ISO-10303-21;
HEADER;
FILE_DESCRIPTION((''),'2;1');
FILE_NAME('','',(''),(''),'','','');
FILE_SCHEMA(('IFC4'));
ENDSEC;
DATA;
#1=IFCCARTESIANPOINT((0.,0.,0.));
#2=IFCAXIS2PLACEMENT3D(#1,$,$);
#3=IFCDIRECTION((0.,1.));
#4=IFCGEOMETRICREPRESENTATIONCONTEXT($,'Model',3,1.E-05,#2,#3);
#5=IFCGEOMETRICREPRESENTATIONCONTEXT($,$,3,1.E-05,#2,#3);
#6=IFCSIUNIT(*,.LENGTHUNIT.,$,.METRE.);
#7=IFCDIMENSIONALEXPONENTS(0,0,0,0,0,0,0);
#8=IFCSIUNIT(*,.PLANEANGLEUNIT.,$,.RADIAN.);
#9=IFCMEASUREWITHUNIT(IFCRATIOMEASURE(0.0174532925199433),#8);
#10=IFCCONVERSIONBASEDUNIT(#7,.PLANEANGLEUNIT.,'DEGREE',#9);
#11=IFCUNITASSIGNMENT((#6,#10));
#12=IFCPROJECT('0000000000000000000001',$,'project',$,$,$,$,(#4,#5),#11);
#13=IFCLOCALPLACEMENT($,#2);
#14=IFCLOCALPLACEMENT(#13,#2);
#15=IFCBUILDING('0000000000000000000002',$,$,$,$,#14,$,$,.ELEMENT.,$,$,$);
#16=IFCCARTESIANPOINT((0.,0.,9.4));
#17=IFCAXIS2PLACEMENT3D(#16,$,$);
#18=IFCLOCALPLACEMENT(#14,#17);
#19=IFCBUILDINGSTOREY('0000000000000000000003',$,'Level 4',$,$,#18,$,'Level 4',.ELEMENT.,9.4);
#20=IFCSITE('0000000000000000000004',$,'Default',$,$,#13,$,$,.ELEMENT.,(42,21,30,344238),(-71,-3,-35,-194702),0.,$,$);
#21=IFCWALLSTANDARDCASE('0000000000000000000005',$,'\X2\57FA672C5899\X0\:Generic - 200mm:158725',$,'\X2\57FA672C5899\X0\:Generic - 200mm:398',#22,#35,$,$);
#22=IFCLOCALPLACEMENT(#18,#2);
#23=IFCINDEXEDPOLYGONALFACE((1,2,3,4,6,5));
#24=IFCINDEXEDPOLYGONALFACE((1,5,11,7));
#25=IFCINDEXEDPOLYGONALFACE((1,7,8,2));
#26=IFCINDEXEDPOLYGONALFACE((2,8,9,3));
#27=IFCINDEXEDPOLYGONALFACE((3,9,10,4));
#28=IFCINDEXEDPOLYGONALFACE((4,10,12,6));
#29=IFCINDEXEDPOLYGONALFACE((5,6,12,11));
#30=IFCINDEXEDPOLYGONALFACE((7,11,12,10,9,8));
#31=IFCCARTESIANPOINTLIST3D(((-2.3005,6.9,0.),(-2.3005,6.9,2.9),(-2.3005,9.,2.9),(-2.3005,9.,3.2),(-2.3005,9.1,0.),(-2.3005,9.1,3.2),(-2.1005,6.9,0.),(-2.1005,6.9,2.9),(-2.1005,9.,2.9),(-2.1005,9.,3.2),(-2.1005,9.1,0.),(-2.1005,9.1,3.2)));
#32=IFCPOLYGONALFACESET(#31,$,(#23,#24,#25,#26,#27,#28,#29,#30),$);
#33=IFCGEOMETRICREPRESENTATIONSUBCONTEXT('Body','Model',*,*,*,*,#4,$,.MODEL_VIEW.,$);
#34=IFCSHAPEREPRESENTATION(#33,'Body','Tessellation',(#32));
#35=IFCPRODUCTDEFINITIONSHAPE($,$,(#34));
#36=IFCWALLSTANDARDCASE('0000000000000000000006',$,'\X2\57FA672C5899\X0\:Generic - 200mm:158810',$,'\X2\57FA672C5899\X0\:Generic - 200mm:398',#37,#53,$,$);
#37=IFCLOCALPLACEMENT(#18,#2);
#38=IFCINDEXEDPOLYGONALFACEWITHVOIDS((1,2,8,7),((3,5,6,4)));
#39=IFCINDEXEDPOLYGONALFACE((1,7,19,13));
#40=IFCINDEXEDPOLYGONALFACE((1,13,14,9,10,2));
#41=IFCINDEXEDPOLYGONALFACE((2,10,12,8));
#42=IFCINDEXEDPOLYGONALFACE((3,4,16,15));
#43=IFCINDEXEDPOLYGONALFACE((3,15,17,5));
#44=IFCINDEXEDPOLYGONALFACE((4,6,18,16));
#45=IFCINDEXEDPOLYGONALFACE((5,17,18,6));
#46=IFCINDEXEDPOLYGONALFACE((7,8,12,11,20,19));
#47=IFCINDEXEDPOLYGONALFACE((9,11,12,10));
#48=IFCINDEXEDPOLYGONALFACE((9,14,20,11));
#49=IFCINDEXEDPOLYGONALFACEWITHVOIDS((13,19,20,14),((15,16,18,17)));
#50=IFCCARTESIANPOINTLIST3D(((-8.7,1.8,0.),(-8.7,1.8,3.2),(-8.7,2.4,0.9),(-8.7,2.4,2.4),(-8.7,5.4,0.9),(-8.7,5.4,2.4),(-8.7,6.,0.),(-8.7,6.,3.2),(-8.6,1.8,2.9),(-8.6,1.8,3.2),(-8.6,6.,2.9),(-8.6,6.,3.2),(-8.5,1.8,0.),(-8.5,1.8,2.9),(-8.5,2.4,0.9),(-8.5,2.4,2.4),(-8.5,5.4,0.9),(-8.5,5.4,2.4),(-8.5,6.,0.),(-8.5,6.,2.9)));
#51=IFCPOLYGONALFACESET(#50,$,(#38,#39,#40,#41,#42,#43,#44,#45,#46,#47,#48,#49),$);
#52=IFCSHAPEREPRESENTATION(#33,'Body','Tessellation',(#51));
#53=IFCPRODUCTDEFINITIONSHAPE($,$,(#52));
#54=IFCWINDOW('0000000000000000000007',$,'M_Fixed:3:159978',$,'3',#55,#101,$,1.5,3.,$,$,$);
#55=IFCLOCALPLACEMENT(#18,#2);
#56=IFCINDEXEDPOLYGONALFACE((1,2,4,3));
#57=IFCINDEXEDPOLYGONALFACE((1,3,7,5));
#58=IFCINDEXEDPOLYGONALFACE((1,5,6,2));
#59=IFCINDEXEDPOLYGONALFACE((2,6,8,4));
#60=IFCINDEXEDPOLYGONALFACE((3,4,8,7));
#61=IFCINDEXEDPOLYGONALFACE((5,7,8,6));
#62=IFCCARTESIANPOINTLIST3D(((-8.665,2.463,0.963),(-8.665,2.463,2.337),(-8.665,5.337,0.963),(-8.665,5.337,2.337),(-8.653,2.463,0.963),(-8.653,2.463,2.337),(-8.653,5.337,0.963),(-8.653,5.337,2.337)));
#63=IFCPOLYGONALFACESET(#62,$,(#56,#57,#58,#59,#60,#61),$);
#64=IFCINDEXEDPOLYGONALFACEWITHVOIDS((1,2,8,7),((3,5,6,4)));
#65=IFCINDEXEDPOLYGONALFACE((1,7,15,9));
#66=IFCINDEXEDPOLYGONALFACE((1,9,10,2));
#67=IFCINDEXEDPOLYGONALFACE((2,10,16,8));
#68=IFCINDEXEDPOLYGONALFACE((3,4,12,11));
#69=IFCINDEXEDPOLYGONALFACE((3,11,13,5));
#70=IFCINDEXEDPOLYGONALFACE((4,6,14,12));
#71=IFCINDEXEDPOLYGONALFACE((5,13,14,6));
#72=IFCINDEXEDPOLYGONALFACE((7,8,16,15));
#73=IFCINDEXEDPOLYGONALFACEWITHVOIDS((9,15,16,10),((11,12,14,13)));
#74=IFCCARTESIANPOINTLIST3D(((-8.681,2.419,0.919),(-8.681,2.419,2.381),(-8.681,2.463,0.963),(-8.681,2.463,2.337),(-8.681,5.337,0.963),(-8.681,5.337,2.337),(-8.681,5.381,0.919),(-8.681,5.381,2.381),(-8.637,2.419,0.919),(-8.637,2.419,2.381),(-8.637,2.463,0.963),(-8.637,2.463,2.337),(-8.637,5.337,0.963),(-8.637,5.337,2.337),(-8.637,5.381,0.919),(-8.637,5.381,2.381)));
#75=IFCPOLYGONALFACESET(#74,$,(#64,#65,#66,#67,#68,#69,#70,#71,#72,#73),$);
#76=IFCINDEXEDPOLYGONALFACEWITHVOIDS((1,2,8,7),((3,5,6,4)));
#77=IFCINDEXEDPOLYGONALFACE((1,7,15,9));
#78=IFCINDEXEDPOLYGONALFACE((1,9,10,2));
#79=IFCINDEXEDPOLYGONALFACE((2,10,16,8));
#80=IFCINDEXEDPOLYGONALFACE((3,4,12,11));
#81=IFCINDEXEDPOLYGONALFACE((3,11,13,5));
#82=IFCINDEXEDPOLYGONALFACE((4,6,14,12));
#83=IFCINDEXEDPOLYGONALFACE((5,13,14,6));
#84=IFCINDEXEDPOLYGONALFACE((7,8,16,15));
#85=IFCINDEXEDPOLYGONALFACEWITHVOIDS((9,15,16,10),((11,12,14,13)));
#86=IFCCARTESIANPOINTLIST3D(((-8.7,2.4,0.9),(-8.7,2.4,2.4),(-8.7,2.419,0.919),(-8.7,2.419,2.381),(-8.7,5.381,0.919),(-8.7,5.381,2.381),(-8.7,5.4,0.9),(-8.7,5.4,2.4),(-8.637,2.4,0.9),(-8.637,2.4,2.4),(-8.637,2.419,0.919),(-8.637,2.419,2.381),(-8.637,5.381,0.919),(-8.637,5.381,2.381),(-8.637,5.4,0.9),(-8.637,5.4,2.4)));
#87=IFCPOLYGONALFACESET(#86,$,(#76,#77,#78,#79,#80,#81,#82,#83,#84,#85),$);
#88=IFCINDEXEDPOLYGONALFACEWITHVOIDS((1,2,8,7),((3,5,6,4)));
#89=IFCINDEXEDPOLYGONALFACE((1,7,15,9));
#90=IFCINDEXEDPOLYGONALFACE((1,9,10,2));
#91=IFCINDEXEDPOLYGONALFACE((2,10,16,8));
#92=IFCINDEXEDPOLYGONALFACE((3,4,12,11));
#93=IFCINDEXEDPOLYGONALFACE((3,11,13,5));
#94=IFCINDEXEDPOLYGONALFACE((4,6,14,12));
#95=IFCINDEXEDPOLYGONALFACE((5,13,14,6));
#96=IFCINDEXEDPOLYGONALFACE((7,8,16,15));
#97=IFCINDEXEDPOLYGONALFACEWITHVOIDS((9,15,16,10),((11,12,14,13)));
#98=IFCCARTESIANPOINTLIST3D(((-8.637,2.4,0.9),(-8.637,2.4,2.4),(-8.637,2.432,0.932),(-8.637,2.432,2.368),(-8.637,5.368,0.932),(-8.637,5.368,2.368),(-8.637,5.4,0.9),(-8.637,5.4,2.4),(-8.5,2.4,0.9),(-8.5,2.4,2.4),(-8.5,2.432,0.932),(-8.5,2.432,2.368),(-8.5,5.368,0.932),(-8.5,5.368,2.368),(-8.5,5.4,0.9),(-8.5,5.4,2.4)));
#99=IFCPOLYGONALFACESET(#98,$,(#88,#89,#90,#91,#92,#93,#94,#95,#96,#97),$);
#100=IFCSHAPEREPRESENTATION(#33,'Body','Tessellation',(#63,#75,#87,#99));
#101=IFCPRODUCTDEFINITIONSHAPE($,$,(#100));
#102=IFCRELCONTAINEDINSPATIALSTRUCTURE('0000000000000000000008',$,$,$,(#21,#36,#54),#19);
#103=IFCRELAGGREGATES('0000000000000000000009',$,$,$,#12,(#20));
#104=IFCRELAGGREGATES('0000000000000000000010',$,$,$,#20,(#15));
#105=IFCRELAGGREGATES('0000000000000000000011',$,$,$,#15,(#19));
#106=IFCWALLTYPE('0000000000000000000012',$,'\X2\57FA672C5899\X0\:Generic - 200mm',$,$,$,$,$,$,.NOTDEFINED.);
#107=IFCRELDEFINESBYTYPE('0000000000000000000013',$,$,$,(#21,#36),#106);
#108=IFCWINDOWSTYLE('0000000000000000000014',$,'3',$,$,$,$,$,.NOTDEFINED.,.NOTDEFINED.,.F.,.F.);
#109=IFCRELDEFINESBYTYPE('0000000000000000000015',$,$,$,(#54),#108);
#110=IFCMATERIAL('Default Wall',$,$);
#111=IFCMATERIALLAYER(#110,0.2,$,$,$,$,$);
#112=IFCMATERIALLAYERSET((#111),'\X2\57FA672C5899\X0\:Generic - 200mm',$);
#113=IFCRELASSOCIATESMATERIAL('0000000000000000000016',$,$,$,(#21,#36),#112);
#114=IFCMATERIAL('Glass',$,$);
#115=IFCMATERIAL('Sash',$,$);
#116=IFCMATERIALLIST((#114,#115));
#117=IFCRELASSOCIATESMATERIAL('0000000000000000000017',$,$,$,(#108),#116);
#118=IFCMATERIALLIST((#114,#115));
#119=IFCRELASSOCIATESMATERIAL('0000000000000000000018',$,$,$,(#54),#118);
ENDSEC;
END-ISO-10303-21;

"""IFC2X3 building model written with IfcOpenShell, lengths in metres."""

from ifc_helpers import new_model, entity, si_unit, converted_unit, direction, frame, frame_2d, origin, place, context, subcontext, project, spatial, polyline, rectangle, outline, extrude, clip, bounded_halfspace, source, transform, mapped, material, material_list, layer, layer_set, layer_usage, type_object, type_shapes, element, fill, save


model = new_model("IFC2X3")

# Units and contexts
model_context = context("Model", 3, precision=1e-05, world=origin(), true_north=direction((0.0, 1.0)))
context_of_model = context(None, 3, precision=1e-05, world=origin(), true_north=direction((0.0, 1.0)))
body_context = subcontext(model_context, "Body", "Model", "MODEL_VIEW")
ifc_project = project(units=[si_unit("LENGTHUNIT", "METRE"), converted_unit("PLANEANGLEUNIT", "DEGREE", entity("IfcRatioMeasure", 0.0174532925199433), si_unit("PLANEANGLEUNIT", "RADIAN"), dimensions=[0, 0, 0, 0, 0, 0, 0])], contexts=[model_context, context_of_model])

# Site, building, storey
site_placement = place(None, origin())
site = spatial("IfcSite", under=ifc_project, at=site_placement, Name="Default", CompositionType="ELEMENT", RefLatitude=(42, 21, 30, 344238), RefLongitude=(-71, -3, -35, -194702), RefElevation=0.0)
building_placement = place(site_placement, origin())
building = spatial("IfcBuilding", under=site, at=building_placement, CompositionType="ELEMENT")
storey_placement = place(building_placement, frame((0.0, 0.0, 9.4)))
storey = spatial("IfcBuildingStorey", under=building, at=storey_placement, Name="Level 4", LongName="Level 4", CompositionType="ELEMENT", Elevation=9.4)

# Wall
ifc_material_1 = material(Name="Default Wall")
ifc_layer_1 = layer(ifc_material_1, 0.2)
ifc_layer_set_1 = layer_set([ifc_layer_1], Name="基本墙:Generic - 200mm")
ifc_layer_usage_1 = layer_usage(ifc_layer_set_1, "AXIS2", "NEGATIVE", 0.1)
wall_type_1 = type_object("IfcWallType", Name="基本墙:Generic - 200mm", PredefinedType="NOTDEFINED")
wall_1_placement = place(storey_placement, frame((-2.2005, 6.9, 0.0), z_axis=(0.0, 0.0, 1.0), x_axis=(0.0, 1.0, 0.0)))
element("IfcWallStandardCase", 1, at=wall_1_placement, inside=storey, type_object=wall_type_1, material=ifc_layer_usage_1, Name="基本墙:Generic - 200mm:158725", ObjectType="基本墙:Generic - 200mm:398", context=body_context, shape_type="Clipping", body=[
    clip(clip(extrude(rectangle(XDim=2.2, YDim=0.2, at=frame_2d((1.1, 0.0), x_axis=(-1.0, 0.0))), origin(), (0.0, 0.0, 1.0), 3.2), bounded_halfspace(frame((2.1, -0.1, 2.9), z_axis=(0.0, 0.0, -1.0), x_axis=(-1.0, 0.0, 0.0)), True, frame((2.1, -0.1, 2.9), z_axis=(0.0, 0.0, -1.0), x_axis=(-1.0, 0.0, 0.0)), polyline([(0.0, 0.0), (0.1, 0.0), (2.1, 0.0), (2.1, 0.1), (2.1, 0.2), (2.0, 0.2), (0.0, 0.2), (0.0, 0.0)]))), bounded_halfspace(frame((2.1, 0.1, 2.9), z_axis=(1.0, 0.0, 0.0), x_axis=(0.0, 0.0, 1.0)), True, frame((2.1, 0.1, 2.9), z_axis=(1.0, 0.0, 0.0), x_axis=(0.0, 0.0, 1.0)), polyline([(0.0, 0.0), (0.3, 0.0), (0.3, 0.2), (0.0, 0.2), (0.0, 0.0)]))),
])

# Wall, opening, window
ifc_layer_usage_2 = layer_usage(ifc_layer_set_1, "AXIS2", "NEGATIVE", 0.1)
wall_2_placement = place(storey_placement, frame((-8.6, 1.8, 0.0), z_axis=(0.0, 0.0, 1.0), x_axis=(0.0, 1.0, 0.0)))
wall_2 = element("IfcWallStandardCase", 2, at=wall_2_placement, inside=storey, type_object=wall_type_1, material=ifc_layer_usage_2, Name="基本墙:Generic - 200mm:158810", ObjectType="基本墙:Generic - 200mm:398", context=body_context, shape_type="Clipping", body=[
    clip(clip(extrude(rectangle(XDim=4.2, YDim=0.2, at=frame_2d((2.1, 0.0), x_axis=(-1.0, 0.0))), origin(), (0.0, 0.0, 1.0), 3.2), bounded_halfspace(frame((4.2, 0.0, 2.9), z_axis=(0.0, 0.0, -1.0), x_axis=(-1.0, 0.0, 0.0)), True, frame((4.2, 0.0, 2.9), z_axis=(0.0, 0.0, -1.0), x_axis=(-1.0, 0.0, 0.0)), polyline([(0.0, 0.0), (0.0, -0.1), (0.1, -0.1), (4.1, -0.1), (4.2, -0.1), (4.2, 0.0), (0.0, 0.0)]))), bounded_halfspace(frame((0.0, 0.0, 2.9), z_axis=(0.0, 1.0, 0.0), x_axis=(0.0, 0.0, 1.0)), True, frame((0.0, 0.0, 2.9), z_axis=(0.0, 1.0, 0.0), x_axis=(0.0, 0.0, 1.0)), polyline([(0.0, 0.0), (0.3, 0.0), (0.3, 4.2), (0.0, 4.2), (0.0, 0.0)]))),
])
opening_1_placement = place(wall_2_placement, frame((0.6, -0.1, 0.9)))
opening_1 = element("IfcOpeningElement", 3, at=opening_1_placement, cuts=wall_2, ObjectType="Opening", context=body_context, shape_type="SweptSolid", body=[
    extrude(rectangle(XDim=1.5, YDim=3.0, at=frame_2d((0.75, 1.5), x_axis=(1.0, 0.0))), frame((0.0, 0.0, 0.0), z_axis=(0.0, 1.0, 0.0), x_axis=(0.0, 0.0, 1.0)), (0.0, 0.0, 1.0), 0.2),
])
ifc_material_2 = material(Name="Glass")
ifc_material_3 = material(Name="Sash")
ifc_material_list_1 = material_list([ifc_material_2, ifc_material_3])
ifc_material_list_2 = material_list([ifc_material_2, ifc_material_3])
window_style_1 = type_object("IfcWindowStyle", Name="3", ConstructionType="NOTDEFINED", OperationType="NOTDEFINED", ParameterTakesPrecedence=False, Sizeable=False, material=ifc_material_list_2)
shared_shape_1 = source(origin(), body_context, "Body", "SweptSolid", [
    extrude(rectangle(XDim=0.012, YDim=2.874, at=frame_2d((0.0, 0.0), x_axis=(1.0, 0.0))), frame((1.5, 0.159, 0.063), z_axis=(0.0, 0.0, 1.0), x_axis=(0.0, -1.0, 0.0)), (0.0, 0.0, 1.0), 1.374),
    extrude(outline(polyline([(-1.481, -0.731), (1.481, -0.731), (1.481, 0.731), (-1.481, 0.731), (-1.481, -0.731)]), holes=[polyline([(-1.437, -0.687), (-1.437, 0.687), (1.437, 0.687), (1.437, -0.687), (-1.437, -0.687)])]), frame((1.5, 0.137, 0.75), z_axis=(0.0, 1.0, 0.0), x_axis=(1.0, 0.0, 0.0)), (0.0, 0.0, 1.0), 0.044),
    extrude(outline(polyline([(-1.5, -0.75), (1.5, -0.75), (1.5, 0.75), (-1.5, 0.75), (-1.5, -0.75)]), holes=[polyline([(-1.481, -0.731), (-1.481, 0.731), (1.481, 0.731), (1.481, -0.731), (-1.481, -0.731)])]), frame((1.5, 0.137, 0.75), z_axis=(0.0, 1.0, 0.0), x_axis=(1.0, 0.0, 0.0)), (0.0, 0.0, 1.0), 0.063),
    extrude(outline(polyline([(-1.5, -0.75), (1.5, -0.75), (1.5, 0.75), (-1.5, 0.75), (-1.5, -0.75)]), holes=[polyline([(-1.468, -0.718), (-1.468, 0.718), (1.468, 0.718), (1.468, -0.718), (-1.468, -0.718)])]), frame((1.5, 0.0, 0.75), z_axis=(0.0, 1.0, 0.0), x_axis=(1.0, 0.0, 0.0)), (0.0, 0.0, 1.0), 0.137),
])
type_shapes(window_style_1, [shared_shape_1])
window_1_placement = place(opening_1_placement, origin())
window_1 = element("IfcWindow", 4, at=window_1_placement, inside=storey, type_object=window_style_1, material=ifc_material_list_1, Name="M_Fixed:3:159978", ObjectType="3", OverallHeight=1.5, OverallWidth=3.0, context=body_context, shape_type="MappedRepresentation", body=[
    mapped(shared_shape_1, transform((0.0, 0.0, 0.0), scale=1.0)),
])
fill(opening_1, window_1)

save(model, "model.ifc")
